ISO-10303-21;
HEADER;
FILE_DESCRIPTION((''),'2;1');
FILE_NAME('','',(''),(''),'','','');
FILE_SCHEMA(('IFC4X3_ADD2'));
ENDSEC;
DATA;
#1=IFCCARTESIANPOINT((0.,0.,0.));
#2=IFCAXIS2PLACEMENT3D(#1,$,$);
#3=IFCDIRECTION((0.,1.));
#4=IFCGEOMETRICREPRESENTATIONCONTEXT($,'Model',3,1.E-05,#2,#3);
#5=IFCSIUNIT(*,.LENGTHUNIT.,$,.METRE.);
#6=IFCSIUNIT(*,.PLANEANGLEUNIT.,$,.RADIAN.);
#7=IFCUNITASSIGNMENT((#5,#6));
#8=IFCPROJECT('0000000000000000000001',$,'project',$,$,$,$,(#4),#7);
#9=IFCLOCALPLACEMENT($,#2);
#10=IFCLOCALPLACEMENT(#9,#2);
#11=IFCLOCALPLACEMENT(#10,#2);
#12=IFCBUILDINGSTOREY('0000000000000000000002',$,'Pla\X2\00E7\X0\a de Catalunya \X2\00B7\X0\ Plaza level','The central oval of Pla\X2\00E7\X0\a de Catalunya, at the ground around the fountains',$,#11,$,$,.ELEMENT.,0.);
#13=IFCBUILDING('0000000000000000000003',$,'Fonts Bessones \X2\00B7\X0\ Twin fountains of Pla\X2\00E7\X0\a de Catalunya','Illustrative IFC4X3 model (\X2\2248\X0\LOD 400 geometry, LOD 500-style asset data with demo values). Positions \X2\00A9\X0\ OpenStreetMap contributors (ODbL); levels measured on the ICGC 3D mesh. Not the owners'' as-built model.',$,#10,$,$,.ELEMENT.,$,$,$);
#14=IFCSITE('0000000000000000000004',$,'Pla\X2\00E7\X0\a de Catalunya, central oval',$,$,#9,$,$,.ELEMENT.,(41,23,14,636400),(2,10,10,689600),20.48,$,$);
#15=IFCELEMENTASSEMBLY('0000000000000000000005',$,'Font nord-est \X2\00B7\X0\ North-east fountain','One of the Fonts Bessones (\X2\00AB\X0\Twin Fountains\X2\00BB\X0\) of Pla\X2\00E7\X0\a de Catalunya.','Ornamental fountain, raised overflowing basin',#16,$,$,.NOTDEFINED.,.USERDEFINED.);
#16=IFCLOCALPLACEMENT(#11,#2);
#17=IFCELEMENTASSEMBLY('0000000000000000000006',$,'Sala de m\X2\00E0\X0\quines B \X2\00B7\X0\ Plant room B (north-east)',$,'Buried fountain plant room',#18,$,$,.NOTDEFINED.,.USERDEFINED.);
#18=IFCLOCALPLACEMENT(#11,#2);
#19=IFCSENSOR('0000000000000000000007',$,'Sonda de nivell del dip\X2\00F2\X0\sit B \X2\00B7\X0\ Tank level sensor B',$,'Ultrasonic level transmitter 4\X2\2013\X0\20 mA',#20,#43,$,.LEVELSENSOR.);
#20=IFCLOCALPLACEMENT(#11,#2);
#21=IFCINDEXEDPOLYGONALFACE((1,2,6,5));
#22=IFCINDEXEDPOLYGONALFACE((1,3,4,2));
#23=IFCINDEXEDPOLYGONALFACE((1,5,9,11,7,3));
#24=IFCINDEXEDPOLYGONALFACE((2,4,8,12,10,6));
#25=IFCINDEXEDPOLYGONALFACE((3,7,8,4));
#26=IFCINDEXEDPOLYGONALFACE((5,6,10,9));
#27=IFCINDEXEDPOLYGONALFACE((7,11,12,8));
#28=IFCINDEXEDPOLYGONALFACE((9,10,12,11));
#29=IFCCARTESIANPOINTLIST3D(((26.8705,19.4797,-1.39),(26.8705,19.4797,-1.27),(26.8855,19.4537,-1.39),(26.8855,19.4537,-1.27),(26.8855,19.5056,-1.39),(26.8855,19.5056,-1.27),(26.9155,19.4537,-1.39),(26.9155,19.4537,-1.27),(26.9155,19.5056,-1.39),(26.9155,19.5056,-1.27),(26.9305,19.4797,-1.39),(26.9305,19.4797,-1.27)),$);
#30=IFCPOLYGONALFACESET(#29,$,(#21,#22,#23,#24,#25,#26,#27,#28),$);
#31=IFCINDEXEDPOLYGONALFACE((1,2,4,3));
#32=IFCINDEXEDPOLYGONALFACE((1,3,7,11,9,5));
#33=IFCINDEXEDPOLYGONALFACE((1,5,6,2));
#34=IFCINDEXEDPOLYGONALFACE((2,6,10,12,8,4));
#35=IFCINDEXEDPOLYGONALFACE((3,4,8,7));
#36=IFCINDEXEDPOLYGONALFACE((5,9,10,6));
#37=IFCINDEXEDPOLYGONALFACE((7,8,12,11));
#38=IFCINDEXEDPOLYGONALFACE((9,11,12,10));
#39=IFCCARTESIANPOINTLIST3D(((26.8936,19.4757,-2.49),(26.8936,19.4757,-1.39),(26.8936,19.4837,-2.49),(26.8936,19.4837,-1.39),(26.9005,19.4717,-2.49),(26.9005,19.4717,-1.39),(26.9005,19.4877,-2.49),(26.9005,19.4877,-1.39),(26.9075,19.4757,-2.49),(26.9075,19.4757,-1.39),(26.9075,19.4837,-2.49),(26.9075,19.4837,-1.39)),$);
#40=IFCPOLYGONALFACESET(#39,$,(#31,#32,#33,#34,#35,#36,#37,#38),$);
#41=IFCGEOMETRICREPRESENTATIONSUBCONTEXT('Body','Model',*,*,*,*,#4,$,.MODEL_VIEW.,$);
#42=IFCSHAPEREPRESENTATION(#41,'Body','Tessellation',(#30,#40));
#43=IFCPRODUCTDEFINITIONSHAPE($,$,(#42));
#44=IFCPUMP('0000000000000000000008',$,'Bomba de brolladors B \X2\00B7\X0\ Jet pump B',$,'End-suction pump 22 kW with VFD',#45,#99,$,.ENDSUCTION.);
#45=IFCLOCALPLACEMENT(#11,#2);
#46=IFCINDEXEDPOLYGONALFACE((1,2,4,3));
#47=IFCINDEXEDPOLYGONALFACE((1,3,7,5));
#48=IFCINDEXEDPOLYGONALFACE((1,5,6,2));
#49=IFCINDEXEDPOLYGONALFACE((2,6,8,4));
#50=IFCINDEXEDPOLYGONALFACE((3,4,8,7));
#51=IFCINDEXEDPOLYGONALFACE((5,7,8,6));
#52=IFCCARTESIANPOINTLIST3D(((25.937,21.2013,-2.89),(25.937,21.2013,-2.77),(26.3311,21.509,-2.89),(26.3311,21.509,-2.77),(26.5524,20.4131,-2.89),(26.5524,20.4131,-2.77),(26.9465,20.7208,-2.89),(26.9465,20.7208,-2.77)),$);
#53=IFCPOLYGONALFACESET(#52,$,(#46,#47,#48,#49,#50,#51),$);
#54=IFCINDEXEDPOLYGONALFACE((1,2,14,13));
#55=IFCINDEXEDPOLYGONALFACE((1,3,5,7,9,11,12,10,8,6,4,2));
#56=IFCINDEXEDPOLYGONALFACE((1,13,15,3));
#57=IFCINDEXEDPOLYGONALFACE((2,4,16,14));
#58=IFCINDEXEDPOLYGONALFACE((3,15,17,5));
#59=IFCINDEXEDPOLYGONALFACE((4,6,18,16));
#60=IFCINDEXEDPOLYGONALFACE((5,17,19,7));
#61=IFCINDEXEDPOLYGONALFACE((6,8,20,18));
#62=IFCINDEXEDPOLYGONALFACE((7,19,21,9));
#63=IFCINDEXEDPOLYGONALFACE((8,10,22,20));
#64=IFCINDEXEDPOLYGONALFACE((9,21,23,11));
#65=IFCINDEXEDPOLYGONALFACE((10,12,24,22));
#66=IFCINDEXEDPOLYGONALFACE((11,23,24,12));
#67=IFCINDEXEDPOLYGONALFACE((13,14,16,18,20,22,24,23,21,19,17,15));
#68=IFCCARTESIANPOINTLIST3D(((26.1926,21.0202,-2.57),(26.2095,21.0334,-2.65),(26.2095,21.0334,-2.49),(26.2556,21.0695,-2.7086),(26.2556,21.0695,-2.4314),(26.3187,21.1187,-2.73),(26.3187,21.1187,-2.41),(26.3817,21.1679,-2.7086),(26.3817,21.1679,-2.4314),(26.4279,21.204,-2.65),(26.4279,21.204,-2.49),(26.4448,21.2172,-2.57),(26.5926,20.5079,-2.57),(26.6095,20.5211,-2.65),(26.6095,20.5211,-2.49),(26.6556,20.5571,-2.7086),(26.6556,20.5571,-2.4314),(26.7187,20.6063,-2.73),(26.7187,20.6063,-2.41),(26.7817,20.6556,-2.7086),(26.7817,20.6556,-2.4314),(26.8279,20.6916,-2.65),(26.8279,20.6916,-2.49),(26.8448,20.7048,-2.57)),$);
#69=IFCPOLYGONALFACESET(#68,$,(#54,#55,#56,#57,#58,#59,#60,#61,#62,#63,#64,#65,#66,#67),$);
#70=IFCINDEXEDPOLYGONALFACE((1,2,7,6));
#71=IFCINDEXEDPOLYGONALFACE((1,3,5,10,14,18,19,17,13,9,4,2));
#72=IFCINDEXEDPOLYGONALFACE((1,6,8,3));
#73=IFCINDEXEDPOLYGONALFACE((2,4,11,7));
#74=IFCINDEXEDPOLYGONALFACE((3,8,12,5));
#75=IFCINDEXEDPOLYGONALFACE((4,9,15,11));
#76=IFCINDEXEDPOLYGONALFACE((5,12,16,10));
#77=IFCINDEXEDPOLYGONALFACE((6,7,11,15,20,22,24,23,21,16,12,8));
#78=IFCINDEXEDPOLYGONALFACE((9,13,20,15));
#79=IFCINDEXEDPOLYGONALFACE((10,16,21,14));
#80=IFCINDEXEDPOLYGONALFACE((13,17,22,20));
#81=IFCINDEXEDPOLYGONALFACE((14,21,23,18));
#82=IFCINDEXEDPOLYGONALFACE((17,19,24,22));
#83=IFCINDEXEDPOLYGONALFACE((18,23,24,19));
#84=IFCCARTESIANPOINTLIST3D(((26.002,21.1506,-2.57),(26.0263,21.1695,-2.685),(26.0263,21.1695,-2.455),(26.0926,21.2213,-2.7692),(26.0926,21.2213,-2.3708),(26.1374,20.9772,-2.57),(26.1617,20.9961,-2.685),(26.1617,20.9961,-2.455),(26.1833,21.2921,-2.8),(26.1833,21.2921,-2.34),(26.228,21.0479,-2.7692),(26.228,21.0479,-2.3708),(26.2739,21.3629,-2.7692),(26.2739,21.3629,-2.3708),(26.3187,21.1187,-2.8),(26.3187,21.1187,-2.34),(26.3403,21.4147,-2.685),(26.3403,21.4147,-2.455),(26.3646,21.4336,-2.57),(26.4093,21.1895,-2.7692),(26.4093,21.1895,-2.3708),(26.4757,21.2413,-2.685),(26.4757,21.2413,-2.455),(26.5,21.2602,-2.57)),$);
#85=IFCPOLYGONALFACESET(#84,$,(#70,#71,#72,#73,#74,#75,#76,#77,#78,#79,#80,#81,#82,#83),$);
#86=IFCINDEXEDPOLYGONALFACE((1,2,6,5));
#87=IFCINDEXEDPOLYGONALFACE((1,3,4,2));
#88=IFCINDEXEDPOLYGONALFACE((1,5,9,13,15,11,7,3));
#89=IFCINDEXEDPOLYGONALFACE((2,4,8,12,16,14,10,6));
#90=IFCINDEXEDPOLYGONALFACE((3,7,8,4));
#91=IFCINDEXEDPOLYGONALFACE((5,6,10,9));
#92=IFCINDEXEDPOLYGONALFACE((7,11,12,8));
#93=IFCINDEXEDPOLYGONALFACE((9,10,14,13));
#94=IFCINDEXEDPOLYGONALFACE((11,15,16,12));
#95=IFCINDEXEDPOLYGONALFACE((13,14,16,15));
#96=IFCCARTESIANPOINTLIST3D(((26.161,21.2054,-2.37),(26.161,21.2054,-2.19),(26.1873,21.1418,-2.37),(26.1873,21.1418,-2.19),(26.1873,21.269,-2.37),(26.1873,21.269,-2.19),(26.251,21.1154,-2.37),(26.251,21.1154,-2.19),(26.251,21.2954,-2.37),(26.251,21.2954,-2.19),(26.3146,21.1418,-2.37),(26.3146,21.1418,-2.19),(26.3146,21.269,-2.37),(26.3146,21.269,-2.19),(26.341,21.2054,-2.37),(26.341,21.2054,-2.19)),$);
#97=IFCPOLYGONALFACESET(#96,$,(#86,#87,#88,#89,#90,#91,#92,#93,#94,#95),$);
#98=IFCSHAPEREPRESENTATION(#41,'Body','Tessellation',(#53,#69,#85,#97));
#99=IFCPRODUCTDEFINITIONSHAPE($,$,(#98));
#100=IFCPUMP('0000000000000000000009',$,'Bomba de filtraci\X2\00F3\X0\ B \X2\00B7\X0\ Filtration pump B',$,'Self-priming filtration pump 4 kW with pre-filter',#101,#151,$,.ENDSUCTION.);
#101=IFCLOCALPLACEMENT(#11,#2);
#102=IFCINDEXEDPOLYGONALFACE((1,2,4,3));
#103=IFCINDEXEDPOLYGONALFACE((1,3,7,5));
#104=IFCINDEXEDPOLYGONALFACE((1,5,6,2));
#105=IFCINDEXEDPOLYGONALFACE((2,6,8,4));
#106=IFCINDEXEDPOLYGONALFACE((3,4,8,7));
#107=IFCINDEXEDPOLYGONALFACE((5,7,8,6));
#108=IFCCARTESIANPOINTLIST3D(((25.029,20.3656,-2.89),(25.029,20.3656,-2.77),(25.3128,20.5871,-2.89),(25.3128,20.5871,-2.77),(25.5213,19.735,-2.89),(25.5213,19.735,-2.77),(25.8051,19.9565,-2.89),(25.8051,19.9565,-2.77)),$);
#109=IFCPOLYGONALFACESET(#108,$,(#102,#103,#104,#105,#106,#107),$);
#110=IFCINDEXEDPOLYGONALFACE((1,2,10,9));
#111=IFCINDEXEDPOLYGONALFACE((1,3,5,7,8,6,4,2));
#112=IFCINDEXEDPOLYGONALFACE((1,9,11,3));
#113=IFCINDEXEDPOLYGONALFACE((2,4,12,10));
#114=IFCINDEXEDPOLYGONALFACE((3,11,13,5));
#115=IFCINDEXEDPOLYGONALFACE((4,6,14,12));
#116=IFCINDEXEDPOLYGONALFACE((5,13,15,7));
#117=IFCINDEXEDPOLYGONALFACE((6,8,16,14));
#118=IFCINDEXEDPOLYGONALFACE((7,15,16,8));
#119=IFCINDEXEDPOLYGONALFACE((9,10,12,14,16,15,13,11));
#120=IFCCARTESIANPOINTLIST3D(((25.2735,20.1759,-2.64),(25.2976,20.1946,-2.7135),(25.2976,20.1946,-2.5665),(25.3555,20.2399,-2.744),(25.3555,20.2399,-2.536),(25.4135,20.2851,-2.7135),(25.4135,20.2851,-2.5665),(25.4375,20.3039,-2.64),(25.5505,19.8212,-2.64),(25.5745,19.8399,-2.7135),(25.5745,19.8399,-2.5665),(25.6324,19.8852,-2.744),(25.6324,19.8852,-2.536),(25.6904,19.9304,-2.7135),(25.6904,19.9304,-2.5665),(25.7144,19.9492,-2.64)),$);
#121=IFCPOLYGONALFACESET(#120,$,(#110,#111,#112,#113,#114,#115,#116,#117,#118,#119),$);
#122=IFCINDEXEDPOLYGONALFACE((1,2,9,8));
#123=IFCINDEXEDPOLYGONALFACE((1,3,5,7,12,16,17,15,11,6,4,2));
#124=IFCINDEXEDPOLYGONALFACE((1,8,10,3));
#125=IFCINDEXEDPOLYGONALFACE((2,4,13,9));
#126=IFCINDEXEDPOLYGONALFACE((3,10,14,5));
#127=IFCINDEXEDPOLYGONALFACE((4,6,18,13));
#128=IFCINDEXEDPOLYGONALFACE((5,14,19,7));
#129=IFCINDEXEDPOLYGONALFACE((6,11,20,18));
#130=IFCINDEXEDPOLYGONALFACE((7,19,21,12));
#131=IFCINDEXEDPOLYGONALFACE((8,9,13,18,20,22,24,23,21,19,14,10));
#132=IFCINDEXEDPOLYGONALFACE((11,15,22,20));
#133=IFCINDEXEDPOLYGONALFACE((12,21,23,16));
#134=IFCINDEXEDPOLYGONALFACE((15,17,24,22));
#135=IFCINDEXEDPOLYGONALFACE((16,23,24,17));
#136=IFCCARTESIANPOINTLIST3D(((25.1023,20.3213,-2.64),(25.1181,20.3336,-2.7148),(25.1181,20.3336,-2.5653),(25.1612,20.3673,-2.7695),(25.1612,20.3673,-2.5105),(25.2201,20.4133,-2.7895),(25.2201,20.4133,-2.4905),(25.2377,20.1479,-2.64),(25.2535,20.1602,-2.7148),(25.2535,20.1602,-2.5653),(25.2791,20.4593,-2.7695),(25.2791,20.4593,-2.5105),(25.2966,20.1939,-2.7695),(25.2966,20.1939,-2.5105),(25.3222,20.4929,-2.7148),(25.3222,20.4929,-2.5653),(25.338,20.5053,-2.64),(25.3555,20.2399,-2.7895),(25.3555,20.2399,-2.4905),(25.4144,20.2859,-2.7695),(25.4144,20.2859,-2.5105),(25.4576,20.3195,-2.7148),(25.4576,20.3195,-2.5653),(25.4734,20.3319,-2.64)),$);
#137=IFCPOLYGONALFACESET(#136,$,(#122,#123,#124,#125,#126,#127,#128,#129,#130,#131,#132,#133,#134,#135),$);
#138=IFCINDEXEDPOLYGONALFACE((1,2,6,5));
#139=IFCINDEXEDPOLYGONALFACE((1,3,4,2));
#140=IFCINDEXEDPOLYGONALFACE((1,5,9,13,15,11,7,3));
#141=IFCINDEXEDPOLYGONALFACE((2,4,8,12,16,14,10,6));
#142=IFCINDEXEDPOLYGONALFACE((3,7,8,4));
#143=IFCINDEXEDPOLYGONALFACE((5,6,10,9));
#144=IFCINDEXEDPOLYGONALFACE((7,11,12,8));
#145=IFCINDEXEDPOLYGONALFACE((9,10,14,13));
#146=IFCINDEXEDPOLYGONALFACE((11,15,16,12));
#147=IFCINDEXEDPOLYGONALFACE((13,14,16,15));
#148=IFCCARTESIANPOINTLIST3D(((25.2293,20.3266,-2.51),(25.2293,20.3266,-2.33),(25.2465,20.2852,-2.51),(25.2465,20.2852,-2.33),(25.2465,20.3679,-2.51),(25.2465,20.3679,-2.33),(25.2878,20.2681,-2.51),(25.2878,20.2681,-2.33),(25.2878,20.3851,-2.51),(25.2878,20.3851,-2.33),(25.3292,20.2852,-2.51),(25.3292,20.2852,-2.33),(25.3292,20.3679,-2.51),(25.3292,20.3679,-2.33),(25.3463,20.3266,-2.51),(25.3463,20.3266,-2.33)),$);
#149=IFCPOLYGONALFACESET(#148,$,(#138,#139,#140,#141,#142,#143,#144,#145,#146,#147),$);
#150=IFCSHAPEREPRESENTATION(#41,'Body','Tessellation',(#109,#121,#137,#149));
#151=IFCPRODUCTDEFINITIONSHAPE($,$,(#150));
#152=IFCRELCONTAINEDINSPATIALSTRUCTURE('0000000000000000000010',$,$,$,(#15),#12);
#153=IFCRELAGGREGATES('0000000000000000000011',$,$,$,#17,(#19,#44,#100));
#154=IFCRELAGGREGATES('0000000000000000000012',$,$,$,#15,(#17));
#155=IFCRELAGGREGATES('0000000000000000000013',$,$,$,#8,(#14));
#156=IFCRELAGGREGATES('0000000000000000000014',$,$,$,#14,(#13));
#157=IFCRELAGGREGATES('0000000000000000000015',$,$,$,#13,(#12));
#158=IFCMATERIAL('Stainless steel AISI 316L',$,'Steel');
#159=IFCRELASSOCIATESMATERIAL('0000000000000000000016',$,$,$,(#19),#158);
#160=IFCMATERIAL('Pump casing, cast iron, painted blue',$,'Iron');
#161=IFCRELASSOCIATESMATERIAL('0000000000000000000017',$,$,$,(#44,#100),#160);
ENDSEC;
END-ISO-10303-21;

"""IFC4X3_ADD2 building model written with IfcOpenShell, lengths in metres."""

from ifc_helpers import new_model, si_unit, direction, frame, frame_2d, origin, place, context, subcontext, project, spatial, polyline, rectangle, outline, extrude, material, element, aggregate, save


model = new_model("IFC4X3_ADD2")

# Units and contexts
model_context = context("Model", 3, precision=1e-05, world=origin(), true_north=direction((0.0, 1.0)))
body_context = subcontext(model_context, "Body", "Model", "MODEL_VIEW")
ifc_project = project(units=[si_unit("LENGTHUNIT", "METRE"), si_unit("PLANEANGLEUNIT", "RADIAN")], contexts=[model_context])

# Site, building, storey
site_placement = place(None, origin())
site = spatial("IfcSite", under=ifc_project, at=site_placement, Name="Plaça de Catalunya, central oval", CompositionType="ELEMENT", RefLatitude=(41, 23, 14, 636400), RefLongitude=(2, 10, 10, 689600), RefElevation=20.48)
building_placement = place(site_placement, origin())
building = spatial("IfcBuilding", under=site, at=building_placement, Name="Fonts Bessones · Twin fountains of Plaça de Catalunya", Description="Illustrative IFC4X3 model (≈LOD 400 geometry, LOD 500-style asset data with demo values). Positions © OpenStreetMap contributors (ODbL); levels measured on the ICGC 3D mesh. Not the owners' as-built model.", CompositionType="ELEMENT")
storey_placement = place(building_placement, origin())
storey = spatial("IfcBuildingStorey", under=building, at=storey_placement, Name="Plaça de Catalunya · Plaza level", Description="The central oval of Plaça de Catalunya, at the ground around the fountains", CompositionType="ELEMENT", Elevation=0.0)

# Element assemblies
assembly_1_placement = place(building_placement, origin())
assembly_1 = element("IfcElementAssembly", 1, at=assembly_1_placement, inside=storey, Name="Font nord-est · North-east fountain", Description="One of the Fonts Bessones («Twin Fountains») of Plaça de Catalunya.", ObjectType="Ornamental fountain, raised overflowing basin", AssemblyPlace="NOTDEFINED", PredefinedType="USERDEFINED")
assembly_2_placement = place(building_placement, origin())
assembly_2 = element("IfcElementAssembly", 2, at=assembly_2_placement, Name="Sala de màquines B · Plant room B (north-east)", ObjectType="Buried fountain plant room", AssemblyPlace="NOTDEFINED", PredefinedType="USERDEFINED")

# Shared definitions
ifc_material_1 = material(Name="Stainless steel AISI 316L", Category="Steel")

# Sensor
sensor_1_placement = place(building_placement, origin())
sensor_1 = element("IfcSensor", 3, at=sensor_1_placement, material=ifc_material_1, Name="Sonda de nivell del dipòsit B · Tank level sensor B", ObjectType="Ultrasonic level transmitter 4–20 mA", PredefinedType="LEVELSENSOR", context=body_context, shape_type="SweptSolid", body=[
    extrude(outline(polyline([(26.9305, 19.4797), (26.9155, 19.5056), (26.8855, 19.5056), (26.8705, 19.4797), (26.8855, 19.4537), (26.9155, 19.4537), (26.9305, 19.4797)])), frame((0.0, 0.0, -1.39)), (0.0, 0.0, 1.0), 0.12),
    extrude(outline(polyline([(0.008, 0.0), (0.004, 0.0069), (-0.004, 0.0069), (-0.008, 0.0), (-0.004, -0.0069), (0.004, -0.0069), (0.008, 0.0)])), frame((26.9005, 19.4797, -1.39), z_axis=(0.0, 0.0, -1.0), x_axis=(0.0, -1.0, 0.0)), (0.0, 0.0, 1.0), 1.1),
])

# Pumps
ifc_material_2 = material(Name="Pump casing, cast iron, painted blue", Category="Iron")
pump_1_placement = place(building_placement, origin())
pump_1 = element("IfcPump", 4, at=pump_1_placement, material=ifc_material_2, Name="Bomba de brolladors B · Jet pump B", ObjectType="End-suction pump 22 kW with VFD", PredefinedType="ENDSUCTION", context=body_context, shape_type="SweptSolid", body=[
    extrude(rectangle(XDim=1.0, YDim=0.5, at=frame_2d((0.0, 0.0), x_axis=(-0.61539, 0.788223))), frame((26.4418, 20.961, -2.89)), (0.0, 0.0, 1.0), 0.12),
    extrude(outline(polyline([(0.16, 0.0), (0.1386, 0.08), (0.08, 0.1386), (0.0, 0.16), (-0.08, 0.1386), (-0.1386, 0.08), (-0.16, 0.0), (-0.1386, -0.08), (-0.08, -0.1386), (0.0, -0.16), (0.08, -0.1386), (0.1386, -0.08), (0.16, 0.0)])), frame((26.7187, 20.6063, -2.57), z_axis=(-0.61539, 0.788223, 0.0), x_axis=(0.788223, 0.61539, 0.0)), (0.0, 0.0, 1.0), 0.65),
    extrude(outline(polyline([(0.23, 0.0), (0.1992, 0.115), (0.115, 0.1992), (0.0, 0.23), (-0.115, 0.1992), (-0.1992, 0.115), (-0.23, 0.0), (-0.1992, -0.115), (-0.115, -0.1992), (0.0, -0.23), (0.115, -0.1992), (0.1992, -0.115), (0.23, 0.0)])), frame((26.3187, 21.1187, -2.57), z_axis=(-0.61539, 0.788223, 0.0), x_axis=(0.788223, 0.61539, 0.0)), (0.0, 0.0, 1.0), 0.22),
    extrude(outline(polyline([(0.09, 0.0), (0.0636, 0.0636), (0.0, 0.09), (-0.0636, 0.0636), (-0.09, 0.0), (-0.0636, -0.0636), (0.0, -0.09), (0.0636, -0.0636), (0.09, 0.0)])), frame((26.251, 21.2054, -2.37), z_axis=(0.0, 0.0, 1.0), x_axis=(0.0, 1.0, 0.0)), (0.0, 0.0, 1.0), 0.18),
])
pump_2_placement = place(building_placement, origin())
pump_2 = element("IfcPump", 5, at=pump_2_placement, material=ifc_material_2, Name="Bomba de filtració B · Filtration pump B", ObjectType="Self-priming filtration pump 4 kW with pre-filter", PredefinedType="ENDSUCTION", context=body_context, shape_type="SweptSolid", body=[
    extrude(rectangle(XDim=0.8, YDim=0.36, at=frame_2d((0.0, 0.0), x_axis=(-0.61539, 0.788223))), frame((25.4171, 20.161, -2.89)), (0.0, 0.0, 1.0), 0.12),
    extrude(outline(polyline([(0.104, 0.0), (0.0735, 0.0735), (0.0, 0.104), (-0.0735, 0.0735), (-0.104, 0.0), (-0.0735, -0.0735), (0.0, -0.104), (0.0735, -0.0735), (0.104, 0.0)])), frame((25.6324, 19.8852, -2.64), z_axis=(-0.61539, 0.788223, 0.0), x_axis=(0.788223, 0.61539, 0.0)), (0.0, 0.0, 1.0), 0.45),
    extrude(outline(polyline([(0.1495, 0.0), (0.1295, 0.0747), (0.0748, 0.1295), (0.0, 0.1495), (-0.0747, 0.1295), (-0.1295, 0.0747), (-0.1495, 0.0), (-0.1295, -0.0747), (-0.0748, -0.1295), (0.0, -0.1495), (0.0748, -0.1295), (0.1295, -0.0748), (0.1495, 0.0)])), frame((25.3555, 20.2399, -2.64), z_axis=(-0.61539, 0.788223, 0.0), x_axis=(0.788223, 0.61539, 0.0)), (0.0, 0.0, 1.0), 0.22),
    extrude(outline(polyline([(0.0585, 0.0), (0.0414, 0.0414), (0.0, 0.0585), (-0.0414, 0.0414), (-0.0585, 0.0), (-0.0414, -0.0414), (0.0, -0.0585), (0.0414, -0.0414), (0.0585, 0.0)])), frame((25.2878, 20.3266, -2.51), z_axis=(0.0, 0.0, 1.0), x_axis=(0.0, 1.0, 0.0)), (0.0, 0.0, 1.0), 0.18),
])

aggregate(assembly_2, [sensor_1, pump_1, pump_2])

aggregate(assembly_1, [assembly_2])

save(model, "model.ifc")
